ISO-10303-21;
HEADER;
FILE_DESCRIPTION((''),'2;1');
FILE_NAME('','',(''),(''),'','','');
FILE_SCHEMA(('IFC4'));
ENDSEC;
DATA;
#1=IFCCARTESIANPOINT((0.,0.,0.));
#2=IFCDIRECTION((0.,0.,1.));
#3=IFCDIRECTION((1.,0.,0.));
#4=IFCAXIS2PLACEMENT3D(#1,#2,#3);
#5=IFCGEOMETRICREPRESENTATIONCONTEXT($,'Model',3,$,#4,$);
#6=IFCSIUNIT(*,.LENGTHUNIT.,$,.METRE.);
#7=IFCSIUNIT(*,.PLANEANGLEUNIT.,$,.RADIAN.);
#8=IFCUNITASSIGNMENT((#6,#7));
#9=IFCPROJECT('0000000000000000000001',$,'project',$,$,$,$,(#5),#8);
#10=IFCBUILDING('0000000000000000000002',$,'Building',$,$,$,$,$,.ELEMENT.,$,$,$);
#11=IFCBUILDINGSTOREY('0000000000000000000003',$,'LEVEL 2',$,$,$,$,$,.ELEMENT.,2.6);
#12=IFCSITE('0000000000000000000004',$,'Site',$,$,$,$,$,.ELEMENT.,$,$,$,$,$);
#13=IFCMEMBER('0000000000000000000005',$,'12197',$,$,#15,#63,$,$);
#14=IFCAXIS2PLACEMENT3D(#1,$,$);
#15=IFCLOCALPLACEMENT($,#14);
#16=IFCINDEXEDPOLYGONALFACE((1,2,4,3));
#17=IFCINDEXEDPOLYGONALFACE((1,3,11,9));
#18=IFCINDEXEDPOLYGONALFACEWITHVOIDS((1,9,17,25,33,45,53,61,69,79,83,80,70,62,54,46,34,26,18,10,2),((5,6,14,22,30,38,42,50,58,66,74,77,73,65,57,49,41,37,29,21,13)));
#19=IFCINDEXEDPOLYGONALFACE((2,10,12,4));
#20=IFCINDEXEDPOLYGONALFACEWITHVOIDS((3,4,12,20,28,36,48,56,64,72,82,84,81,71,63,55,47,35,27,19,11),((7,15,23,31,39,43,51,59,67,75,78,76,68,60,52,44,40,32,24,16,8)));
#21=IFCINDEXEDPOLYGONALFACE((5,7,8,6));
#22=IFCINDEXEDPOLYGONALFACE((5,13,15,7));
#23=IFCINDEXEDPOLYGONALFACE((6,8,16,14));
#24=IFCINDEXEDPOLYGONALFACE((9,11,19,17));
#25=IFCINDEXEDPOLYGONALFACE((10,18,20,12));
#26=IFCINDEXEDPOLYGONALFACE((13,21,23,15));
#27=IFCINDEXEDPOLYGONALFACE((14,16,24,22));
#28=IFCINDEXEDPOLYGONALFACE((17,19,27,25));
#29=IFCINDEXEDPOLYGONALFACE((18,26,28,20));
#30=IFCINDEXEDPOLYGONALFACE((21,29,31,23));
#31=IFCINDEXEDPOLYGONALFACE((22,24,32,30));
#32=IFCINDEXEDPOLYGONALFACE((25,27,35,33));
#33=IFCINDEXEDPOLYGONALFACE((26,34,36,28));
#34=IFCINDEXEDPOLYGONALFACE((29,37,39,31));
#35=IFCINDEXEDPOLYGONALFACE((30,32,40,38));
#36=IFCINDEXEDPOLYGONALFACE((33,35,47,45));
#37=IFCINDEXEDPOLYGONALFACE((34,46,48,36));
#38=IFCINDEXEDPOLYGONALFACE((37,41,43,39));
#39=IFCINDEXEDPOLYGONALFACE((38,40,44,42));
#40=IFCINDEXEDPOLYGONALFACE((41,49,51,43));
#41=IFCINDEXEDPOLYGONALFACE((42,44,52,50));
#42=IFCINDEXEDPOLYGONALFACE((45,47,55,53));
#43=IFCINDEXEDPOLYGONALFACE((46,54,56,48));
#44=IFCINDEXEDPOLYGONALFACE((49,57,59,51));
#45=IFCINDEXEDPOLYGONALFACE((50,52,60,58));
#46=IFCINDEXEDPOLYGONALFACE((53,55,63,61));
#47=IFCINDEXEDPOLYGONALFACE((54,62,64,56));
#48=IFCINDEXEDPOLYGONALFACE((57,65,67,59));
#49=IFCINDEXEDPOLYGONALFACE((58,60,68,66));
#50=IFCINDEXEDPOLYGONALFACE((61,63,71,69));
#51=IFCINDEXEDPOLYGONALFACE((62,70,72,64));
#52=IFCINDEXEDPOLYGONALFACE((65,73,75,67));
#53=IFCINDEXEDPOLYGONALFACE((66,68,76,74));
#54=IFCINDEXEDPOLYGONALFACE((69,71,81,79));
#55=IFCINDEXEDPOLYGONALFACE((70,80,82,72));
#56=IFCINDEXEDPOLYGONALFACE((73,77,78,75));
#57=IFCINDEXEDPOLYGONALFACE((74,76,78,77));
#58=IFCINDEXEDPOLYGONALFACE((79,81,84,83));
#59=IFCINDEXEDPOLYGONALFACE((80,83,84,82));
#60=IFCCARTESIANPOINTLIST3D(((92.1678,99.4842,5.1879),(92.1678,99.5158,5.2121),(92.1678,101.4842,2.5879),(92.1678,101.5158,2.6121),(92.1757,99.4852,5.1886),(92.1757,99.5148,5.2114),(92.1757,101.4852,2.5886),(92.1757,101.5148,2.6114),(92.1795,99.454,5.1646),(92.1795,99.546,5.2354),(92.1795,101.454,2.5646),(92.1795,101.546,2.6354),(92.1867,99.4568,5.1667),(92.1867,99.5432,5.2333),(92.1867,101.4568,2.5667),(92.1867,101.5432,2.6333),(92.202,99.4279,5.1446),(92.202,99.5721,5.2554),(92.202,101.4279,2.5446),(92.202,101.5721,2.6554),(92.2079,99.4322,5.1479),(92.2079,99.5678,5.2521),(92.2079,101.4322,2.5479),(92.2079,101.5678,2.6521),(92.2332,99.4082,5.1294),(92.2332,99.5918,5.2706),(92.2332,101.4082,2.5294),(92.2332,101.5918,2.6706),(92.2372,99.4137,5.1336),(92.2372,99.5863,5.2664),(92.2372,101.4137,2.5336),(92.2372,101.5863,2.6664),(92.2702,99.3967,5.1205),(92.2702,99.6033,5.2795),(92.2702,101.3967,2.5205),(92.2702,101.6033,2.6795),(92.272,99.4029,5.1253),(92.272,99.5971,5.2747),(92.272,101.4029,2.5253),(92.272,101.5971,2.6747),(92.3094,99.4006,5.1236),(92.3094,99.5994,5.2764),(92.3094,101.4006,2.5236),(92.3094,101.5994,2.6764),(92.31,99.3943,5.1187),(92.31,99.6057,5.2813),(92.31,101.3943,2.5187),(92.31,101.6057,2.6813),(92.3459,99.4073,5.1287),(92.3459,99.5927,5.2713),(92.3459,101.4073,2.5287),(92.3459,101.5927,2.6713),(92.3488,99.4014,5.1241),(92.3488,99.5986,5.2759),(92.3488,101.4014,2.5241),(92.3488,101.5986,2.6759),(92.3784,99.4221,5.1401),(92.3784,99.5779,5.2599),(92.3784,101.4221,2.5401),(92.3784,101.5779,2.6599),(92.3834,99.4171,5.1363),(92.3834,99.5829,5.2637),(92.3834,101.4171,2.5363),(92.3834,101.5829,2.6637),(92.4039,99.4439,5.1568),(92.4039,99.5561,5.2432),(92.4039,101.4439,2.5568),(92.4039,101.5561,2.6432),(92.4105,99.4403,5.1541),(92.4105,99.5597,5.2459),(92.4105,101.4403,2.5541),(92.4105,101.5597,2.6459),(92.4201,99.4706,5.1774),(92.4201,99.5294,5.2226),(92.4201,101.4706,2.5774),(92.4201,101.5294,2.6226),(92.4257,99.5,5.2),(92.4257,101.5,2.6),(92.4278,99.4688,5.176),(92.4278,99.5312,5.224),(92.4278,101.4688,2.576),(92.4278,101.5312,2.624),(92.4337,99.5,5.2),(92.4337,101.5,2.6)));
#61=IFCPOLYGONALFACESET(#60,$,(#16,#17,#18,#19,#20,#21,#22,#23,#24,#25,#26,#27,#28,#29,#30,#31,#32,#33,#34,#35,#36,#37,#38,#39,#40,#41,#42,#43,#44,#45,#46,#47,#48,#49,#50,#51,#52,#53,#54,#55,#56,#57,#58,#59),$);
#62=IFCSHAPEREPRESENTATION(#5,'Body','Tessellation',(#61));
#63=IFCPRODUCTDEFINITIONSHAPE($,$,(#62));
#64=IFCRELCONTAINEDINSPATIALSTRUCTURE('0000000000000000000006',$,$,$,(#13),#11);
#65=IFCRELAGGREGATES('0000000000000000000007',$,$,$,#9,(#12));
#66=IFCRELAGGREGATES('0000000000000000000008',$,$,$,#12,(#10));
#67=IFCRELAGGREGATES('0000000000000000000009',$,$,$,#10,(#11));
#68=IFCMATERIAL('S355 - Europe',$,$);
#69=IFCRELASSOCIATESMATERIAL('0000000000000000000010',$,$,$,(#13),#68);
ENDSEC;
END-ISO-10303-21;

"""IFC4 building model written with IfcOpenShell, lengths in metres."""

from ifc_helpers import new_model, si_unit, frame, origin_with_axes, origin_2d_with_axis, place, context, project, spatial, hollow_circle, extrude, material, material_profile, profile_set, profile_usage, element, save


model = new_model("IFC4")

# Units and contexts
model_context = context("Model", 3, world=origin_with_axes())
ifc_project = project(units=[si_unit("LENGTHUNIT", "METRE"), si_unit("PLANEANGLEUNIT", "RADIAN")], contexts=[model_context])

# Site, building, storey
site = spatial("IfcSite", under=ifc_project, Name="Site", CompositionType="ELEMENT")
building = spatial("IfcBuilding", under=site, Name="Building", CompositionType="ELEMENT")
storey = spatial("IfcBuildingStorey", under=building, Name="LEVEL 2", CompositionType="ELEMENT", Elevation=2.6)

# Shared definitions
ifc_material = material(Name="S355 - Europe")

# Member
ifc_material_profile_1 = material_profile(ifc_material, hollow_circle(Radius=0.1337, WallThickness=0.008, at=origin_2d_with_axis()))
ifc_profile_set_1 = profile_set([ifc_material_profile_1])
ifc_profile_usage_1 = profile_usage(ifc_profile_set_1, cardinal=10)
member_1_placement = place(None, frame((92.3, 101.5, 2.6), z_axis=(0.0, -0.609711, 0.792624), x_axis=(1.0, 0.0, 0.0)))
element("IfcMember", 1, at=member_1_placement, inside=storey, material=ifc_profile_usage_1, Name="12197", context=model_context, shape_type="SweptSolid", body=[
    extrude(hollow_circle(Radius=0.1337, WallThickness=0.008, at=origin_2d_with_axis()), origin_with_axes(), (0.0, 0.0, 1.0), 3.2802),
])

save(model, "model.ifc")
